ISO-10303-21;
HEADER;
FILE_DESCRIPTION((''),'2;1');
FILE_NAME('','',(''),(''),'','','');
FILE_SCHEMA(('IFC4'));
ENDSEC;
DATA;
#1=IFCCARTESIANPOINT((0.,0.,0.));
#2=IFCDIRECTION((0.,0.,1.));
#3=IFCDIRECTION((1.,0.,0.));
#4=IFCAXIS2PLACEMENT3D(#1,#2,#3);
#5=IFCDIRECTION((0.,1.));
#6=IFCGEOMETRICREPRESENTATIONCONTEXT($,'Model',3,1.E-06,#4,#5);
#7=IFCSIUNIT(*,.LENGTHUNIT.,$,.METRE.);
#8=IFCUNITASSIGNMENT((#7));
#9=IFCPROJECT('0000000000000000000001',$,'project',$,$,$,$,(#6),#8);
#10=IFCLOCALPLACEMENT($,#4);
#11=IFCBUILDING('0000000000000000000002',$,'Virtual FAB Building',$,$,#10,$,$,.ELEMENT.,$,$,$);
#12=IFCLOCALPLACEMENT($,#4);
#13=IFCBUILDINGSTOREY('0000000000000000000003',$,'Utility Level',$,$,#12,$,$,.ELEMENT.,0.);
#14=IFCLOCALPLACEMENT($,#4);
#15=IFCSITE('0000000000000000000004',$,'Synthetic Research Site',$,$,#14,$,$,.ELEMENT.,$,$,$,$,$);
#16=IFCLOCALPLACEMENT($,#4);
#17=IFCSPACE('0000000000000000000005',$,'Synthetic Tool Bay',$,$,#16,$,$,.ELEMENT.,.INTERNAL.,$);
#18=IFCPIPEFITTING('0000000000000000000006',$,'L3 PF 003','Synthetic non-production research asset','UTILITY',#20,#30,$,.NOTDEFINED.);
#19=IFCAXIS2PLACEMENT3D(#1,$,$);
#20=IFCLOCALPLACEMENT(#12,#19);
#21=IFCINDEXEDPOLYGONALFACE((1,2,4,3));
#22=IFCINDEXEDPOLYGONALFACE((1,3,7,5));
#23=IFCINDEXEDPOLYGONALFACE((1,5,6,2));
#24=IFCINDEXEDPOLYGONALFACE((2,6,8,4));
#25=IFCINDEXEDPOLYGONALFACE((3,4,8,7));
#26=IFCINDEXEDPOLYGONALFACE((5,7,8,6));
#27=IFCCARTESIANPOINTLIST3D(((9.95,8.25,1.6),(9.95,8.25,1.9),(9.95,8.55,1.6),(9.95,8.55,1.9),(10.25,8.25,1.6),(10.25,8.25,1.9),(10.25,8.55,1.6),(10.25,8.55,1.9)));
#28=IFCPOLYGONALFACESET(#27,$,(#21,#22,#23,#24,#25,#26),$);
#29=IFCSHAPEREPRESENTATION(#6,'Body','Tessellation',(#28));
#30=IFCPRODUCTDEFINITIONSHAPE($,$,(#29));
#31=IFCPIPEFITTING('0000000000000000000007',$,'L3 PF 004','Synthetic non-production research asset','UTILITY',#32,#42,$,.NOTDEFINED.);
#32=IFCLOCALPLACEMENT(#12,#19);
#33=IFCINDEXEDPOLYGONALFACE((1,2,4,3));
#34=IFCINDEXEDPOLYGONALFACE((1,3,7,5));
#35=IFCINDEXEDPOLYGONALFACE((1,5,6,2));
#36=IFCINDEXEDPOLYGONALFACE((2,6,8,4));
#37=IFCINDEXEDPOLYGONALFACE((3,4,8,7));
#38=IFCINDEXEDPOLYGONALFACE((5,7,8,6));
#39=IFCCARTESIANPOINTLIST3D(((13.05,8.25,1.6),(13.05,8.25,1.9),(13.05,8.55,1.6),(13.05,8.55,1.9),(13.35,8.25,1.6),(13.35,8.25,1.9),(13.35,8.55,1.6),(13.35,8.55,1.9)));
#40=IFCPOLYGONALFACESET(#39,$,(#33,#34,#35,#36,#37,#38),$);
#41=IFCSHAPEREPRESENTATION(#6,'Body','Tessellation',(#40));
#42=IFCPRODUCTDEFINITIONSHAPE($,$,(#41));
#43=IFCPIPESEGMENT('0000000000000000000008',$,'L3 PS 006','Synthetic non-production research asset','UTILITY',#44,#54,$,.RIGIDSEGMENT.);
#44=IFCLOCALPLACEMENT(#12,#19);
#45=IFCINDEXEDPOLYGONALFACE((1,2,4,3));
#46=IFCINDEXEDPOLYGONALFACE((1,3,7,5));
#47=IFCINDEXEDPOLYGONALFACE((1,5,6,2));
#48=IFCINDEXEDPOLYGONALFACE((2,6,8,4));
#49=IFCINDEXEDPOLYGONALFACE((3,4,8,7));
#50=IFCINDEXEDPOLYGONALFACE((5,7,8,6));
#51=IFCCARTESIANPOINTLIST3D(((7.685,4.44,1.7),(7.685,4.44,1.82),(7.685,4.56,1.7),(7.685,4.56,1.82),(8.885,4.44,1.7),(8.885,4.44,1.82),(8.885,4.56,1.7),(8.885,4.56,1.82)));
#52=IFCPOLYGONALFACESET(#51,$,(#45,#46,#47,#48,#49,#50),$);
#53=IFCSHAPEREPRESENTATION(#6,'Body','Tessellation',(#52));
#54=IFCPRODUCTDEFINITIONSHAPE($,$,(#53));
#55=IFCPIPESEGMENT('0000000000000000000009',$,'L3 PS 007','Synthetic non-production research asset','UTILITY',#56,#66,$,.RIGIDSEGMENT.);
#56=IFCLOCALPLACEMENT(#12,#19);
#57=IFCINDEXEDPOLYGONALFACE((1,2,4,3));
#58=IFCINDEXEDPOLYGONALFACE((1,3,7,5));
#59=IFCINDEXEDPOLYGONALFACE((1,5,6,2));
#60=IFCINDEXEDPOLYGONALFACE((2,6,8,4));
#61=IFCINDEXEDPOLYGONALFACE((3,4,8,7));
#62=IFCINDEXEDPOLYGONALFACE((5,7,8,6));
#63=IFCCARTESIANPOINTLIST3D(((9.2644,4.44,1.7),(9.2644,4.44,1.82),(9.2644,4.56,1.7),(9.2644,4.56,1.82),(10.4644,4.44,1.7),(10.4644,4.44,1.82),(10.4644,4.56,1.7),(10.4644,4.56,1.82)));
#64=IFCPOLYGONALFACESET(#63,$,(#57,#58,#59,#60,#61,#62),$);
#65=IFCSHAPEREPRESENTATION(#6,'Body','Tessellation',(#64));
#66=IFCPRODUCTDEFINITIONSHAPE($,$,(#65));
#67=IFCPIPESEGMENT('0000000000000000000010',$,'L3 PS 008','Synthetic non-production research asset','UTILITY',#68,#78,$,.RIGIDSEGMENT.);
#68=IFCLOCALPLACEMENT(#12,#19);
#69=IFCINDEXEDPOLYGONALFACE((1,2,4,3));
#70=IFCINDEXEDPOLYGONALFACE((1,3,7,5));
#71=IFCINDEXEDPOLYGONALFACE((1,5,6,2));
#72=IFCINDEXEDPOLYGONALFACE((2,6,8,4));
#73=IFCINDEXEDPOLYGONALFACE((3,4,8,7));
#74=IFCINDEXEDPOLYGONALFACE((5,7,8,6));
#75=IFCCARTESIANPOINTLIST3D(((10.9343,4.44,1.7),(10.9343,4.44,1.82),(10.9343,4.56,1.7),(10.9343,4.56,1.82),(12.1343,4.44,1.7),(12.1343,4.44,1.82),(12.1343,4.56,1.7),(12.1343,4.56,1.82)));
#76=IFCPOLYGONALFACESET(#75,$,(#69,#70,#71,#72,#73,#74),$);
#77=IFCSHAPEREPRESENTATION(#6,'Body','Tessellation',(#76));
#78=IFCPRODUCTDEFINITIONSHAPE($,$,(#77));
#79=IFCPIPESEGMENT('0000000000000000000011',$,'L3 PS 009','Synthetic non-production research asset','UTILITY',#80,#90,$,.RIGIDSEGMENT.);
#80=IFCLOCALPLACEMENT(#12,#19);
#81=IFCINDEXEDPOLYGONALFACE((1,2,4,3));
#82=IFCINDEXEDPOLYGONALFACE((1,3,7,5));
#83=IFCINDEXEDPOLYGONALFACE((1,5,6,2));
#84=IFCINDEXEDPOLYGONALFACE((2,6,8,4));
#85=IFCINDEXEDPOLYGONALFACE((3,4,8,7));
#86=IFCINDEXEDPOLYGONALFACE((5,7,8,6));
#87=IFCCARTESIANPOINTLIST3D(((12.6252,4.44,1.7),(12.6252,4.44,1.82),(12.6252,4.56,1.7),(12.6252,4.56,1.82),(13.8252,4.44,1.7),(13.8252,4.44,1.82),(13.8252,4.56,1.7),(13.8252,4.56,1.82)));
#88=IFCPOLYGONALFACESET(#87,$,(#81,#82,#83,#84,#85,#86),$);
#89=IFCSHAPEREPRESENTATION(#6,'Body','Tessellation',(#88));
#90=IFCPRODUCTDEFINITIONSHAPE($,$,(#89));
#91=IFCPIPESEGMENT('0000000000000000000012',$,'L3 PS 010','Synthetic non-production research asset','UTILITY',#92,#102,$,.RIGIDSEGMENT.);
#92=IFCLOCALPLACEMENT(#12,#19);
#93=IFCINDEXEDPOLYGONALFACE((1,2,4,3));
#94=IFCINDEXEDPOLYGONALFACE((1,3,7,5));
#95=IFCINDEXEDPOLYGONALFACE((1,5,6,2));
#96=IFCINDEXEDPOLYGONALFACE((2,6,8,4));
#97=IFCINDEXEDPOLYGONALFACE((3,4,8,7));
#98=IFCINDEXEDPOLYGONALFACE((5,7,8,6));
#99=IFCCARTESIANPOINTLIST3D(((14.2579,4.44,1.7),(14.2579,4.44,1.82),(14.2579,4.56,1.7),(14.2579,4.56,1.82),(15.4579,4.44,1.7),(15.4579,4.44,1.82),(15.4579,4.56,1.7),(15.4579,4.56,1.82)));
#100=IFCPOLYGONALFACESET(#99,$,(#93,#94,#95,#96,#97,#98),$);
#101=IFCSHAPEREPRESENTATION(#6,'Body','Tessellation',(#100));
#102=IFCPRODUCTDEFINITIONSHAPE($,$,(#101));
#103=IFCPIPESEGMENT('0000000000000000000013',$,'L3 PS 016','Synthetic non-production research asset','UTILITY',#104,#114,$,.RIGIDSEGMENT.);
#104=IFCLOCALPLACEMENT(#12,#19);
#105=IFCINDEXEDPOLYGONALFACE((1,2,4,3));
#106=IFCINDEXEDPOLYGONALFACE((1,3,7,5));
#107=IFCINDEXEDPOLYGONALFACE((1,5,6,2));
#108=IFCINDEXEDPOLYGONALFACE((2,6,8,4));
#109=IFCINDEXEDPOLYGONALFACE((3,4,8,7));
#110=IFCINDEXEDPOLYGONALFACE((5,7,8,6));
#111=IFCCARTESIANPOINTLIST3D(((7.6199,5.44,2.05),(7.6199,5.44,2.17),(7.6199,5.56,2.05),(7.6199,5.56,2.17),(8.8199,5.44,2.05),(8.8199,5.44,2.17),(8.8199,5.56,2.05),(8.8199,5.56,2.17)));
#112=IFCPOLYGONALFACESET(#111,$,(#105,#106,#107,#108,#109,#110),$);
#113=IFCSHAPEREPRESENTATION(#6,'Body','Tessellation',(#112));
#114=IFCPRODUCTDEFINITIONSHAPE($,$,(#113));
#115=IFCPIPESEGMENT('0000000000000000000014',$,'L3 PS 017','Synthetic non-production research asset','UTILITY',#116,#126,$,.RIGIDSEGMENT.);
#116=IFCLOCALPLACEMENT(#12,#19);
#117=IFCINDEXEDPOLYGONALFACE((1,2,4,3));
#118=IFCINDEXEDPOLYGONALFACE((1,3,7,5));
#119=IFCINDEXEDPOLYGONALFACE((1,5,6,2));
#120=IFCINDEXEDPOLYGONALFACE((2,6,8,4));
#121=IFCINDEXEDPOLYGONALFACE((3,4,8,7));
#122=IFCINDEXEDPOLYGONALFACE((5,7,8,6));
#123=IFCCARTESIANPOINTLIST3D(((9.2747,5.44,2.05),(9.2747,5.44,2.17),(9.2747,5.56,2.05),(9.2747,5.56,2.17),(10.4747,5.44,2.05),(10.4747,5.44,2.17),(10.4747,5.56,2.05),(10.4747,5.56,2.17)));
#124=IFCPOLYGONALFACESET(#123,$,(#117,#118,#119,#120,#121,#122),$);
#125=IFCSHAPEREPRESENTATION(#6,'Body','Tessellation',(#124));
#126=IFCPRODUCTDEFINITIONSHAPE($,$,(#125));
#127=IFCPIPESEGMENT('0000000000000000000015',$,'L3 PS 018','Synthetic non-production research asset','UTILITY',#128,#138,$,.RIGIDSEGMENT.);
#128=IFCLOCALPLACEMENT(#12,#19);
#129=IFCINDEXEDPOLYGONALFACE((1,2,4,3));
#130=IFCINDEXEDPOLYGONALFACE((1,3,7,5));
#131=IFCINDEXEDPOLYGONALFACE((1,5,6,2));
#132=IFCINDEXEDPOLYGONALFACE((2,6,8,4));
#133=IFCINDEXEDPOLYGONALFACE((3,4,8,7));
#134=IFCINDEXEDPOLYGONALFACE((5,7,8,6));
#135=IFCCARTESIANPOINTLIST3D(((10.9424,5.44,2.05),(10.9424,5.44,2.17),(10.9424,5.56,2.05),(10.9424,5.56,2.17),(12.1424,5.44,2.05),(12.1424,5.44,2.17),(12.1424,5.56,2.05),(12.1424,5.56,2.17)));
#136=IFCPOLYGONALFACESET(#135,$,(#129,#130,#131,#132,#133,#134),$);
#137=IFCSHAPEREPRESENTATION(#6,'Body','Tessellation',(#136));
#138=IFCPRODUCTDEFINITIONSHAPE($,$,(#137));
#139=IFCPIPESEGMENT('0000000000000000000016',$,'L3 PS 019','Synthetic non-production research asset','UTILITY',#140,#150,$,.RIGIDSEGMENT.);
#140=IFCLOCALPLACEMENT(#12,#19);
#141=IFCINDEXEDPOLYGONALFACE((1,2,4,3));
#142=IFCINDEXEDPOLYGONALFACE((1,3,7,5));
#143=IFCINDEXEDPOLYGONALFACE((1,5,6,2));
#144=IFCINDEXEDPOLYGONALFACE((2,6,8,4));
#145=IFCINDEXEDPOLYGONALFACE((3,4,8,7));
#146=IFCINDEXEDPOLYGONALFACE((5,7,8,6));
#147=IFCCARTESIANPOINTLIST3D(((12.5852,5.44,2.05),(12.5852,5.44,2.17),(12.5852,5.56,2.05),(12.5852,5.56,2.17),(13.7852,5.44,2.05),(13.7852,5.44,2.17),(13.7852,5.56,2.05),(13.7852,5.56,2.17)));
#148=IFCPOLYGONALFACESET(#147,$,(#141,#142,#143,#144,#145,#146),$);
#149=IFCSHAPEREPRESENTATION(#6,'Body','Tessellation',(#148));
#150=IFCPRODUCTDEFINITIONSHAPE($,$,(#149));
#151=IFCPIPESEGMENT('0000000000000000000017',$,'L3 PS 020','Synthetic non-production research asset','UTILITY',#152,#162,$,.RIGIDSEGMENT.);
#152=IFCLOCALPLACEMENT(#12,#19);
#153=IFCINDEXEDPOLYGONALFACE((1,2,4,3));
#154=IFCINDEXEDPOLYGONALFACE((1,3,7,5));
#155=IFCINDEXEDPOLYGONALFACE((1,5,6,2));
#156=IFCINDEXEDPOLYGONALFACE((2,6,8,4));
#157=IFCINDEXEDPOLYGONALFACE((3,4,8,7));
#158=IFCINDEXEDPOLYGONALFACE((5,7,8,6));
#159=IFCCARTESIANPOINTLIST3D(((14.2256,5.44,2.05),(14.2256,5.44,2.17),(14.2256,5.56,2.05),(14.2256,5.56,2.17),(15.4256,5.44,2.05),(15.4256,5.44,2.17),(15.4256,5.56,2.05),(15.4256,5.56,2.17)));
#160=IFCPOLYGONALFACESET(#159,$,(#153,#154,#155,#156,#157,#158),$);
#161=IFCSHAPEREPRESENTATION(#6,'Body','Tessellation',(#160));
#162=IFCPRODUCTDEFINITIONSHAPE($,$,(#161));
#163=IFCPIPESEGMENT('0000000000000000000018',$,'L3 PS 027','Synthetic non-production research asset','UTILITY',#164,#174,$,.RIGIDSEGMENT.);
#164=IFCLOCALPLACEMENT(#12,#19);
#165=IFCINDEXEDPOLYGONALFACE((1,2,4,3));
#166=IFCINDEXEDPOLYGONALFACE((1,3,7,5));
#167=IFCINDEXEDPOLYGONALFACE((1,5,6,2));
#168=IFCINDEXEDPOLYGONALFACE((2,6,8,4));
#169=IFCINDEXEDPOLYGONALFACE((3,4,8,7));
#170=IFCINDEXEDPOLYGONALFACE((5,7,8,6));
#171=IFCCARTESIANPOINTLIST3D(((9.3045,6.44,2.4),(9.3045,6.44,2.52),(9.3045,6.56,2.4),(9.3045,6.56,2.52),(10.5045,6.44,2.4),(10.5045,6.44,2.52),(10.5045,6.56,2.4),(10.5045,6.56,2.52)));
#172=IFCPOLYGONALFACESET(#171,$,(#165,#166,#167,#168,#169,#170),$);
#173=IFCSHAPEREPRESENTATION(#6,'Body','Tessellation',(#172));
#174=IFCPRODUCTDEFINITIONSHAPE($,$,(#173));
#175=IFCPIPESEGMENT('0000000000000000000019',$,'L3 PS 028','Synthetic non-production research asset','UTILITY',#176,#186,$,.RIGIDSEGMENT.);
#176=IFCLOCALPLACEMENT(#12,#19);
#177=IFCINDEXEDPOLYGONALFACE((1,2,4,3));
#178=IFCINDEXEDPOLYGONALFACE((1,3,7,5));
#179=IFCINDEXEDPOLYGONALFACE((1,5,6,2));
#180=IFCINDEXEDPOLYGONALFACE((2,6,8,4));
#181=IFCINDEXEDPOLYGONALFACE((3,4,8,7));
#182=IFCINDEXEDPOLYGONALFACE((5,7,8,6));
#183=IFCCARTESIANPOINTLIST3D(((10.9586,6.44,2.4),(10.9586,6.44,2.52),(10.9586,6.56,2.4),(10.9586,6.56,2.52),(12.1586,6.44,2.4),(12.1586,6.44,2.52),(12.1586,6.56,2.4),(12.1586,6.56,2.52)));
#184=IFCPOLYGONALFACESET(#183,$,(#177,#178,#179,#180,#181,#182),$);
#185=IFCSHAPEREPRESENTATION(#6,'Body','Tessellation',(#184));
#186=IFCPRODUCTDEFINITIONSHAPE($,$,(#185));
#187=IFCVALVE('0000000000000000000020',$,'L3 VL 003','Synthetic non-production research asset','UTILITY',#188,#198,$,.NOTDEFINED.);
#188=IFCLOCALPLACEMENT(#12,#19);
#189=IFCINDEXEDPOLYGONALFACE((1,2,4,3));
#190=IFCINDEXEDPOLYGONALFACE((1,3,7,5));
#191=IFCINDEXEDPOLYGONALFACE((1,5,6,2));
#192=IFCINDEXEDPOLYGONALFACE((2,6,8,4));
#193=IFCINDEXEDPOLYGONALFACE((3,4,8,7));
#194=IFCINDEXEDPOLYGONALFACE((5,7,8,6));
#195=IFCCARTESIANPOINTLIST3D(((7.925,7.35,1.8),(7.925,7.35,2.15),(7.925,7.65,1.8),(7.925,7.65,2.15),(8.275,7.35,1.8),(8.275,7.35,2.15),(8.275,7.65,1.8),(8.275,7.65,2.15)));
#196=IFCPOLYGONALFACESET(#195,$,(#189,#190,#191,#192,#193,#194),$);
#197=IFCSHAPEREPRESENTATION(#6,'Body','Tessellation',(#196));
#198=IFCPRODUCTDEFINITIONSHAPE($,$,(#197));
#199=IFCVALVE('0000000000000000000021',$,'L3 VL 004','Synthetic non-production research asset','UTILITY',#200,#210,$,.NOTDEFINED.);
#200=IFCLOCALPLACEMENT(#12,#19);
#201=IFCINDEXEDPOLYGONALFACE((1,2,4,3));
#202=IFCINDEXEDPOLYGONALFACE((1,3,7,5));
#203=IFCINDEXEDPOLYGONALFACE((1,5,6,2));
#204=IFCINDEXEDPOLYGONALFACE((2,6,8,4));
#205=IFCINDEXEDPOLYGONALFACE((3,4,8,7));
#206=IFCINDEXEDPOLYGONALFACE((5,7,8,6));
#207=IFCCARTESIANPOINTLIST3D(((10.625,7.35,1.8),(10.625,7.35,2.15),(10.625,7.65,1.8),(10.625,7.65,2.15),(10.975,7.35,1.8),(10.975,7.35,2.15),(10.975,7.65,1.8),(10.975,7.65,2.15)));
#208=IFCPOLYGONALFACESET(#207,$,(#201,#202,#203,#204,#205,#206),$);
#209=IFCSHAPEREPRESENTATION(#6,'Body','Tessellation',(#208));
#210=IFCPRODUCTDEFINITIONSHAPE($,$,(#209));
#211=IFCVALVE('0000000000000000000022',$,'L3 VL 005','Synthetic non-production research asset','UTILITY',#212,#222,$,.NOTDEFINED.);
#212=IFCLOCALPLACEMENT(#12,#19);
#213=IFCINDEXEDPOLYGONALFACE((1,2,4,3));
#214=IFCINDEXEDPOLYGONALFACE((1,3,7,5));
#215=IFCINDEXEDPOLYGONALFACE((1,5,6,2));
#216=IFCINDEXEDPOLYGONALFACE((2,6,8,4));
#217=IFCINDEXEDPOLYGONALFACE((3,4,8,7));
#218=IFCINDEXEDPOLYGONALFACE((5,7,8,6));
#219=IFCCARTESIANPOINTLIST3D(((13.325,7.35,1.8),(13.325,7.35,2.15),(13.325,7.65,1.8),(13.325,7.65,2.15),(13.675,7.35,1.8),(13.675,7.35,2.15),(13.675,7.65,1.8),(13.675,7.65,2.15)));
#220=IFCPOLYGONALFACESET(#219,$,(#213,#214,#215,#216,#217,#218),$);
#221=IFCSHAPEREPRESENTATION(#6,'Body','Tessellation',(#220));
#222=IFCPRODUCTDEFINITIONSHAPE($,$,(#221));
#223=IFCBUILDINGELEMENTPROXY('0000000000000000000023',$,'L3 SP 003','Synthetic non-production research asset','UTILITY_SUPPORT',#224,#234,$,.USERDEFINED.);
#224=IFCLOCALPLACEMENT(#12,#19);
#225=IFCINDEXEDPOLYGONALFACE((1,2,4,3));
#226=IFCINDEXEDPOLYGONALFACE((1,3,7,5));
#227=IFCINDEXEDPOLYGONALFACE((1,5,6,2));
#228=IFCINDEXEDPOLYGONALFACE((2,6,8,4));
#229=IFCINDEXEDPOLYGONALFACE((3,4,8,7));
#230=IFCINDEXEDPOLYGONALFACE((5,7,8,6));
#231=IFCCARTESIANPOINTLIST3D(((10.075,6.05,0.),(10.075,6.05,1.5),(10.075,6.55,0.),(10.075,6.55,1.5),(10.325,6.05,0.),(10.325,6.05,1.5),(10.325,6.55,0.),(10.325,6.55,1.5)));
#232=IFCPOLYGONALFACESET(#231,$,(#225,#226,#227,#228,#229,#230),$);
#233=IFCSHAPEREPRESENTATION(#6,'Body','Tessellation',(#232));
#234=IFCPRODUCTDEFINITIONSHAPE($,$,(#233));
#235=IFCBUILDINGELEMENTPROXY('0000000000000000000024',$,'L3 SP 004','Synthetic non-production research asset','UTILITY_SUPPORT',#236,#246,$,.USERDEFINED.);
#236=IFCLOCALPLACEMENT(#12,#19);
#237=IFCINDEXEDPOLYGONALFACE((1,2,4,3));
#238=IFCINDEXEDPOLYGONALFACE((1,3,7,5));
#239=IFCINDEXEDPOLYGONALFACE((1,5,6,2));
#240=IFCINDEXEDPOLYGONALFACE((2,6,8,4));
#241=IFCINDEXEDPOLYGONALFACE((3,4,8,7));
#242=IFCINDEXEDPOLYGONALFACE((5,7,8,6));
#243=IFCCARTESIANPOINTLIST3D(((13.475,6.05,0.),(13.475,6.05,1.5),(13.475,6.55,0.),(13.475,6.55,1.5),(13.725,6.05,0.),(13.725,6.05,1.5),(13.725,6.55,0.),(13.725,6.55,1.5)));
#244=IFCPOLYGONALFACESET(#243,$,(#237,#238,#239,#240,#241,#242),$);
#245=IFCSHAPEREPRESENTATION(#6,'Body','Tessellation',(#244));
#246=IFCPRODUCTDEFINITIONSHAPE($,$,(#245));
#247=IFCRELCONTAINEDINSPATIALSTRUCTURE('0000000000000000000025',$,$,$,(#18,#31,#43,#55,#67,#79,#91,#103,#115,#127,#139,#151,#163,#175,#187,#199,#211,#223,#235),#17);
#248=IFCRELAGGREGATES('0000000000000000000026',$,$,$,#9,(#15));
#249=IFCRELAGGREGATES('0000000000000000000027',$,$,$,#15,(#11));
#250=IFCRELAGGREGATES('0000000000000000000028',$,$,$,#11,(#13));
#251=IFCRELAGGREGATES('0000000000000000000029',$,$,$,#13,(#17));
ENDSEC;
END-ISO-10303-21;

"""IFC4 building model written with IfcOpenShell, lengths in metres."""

from ifc_helpers import new_model, si_unit, direction, frame, origin_with_axes, origin_2d_with_axis, place, context, project, spatial, rectangle, extrude, element, save


model = new_model("IFC4")

# Units and contexts
model_context = context("Model", 3, precision=1e-06, world=origin_with_axes(), true_north=direction((0.0, 1.0)))
ifc_project = project(units=[si_unit("LENGTHUNIT", "METRE")], contexts=[model_context])

# Site, building, storey, space
site_placement = place(None, origin_with_axes())
site = spatial("IfcSite", under=ifc_project, at=site_placement, Name="Synthetic Research Site", CompositionType="ELEMENT")
building_placement = place(None, origin_with_axes())
building = spatial("IfcBuilding", under=site, at=building_placement, Name="Virtual FAB Building", CompositionType="ELEMENT")
storey_placement = place(None, origin_with_axes())
storey = spatial("IfcBuildingStorey", under=building, at=storey_placement, Name="Utility Level", CompositionType="ELEMENT", Elevation=0.0)
space_placement = place(None, origin_with_axes())
space = spatial("IfcSpace", under=storey, at=space_placement, Name="Synthetic Tool Bay", CompositionType="ELEMENT", PredefinedType="INTERNAL")

# Pipe fittings
for number, where, z_axis, x_axis, name in (
    (1, (10.1, 8.4, 1.6), (0.0, 0.0, 1.0), (1.0, 0.0, 0.0), "L3 PF 003"),
    (2, (13.2, 8.4, 1.6), (0.0, 0.0, 1.0), (1.0, 0.0, 0.0), "L3 PF 004"),
):
    element("IfcPipeFitting", number, at=place(None, frame(where, z_axis=z_axis, x_axis=x_axis)), inside=space, Name=name, Description="Synthetic non-production research asset", ObjectType="UTILITY", PredefinedType="NOTDEFINED", context=model_context, shape_type="SweptSolid", body=[
        extrude(rectangle(XDim=0.3, YDim=0.3, at=origin_2d_with_axis()), origin_with_axes(), (0.0, 0.0, 1.0), 0.3),
    ])

# Pipe segments
for number, where, z_axis, x_axis, name in (
    (3, (8.285, 4.5, 1.7), (0.0, 0.0, 1.0), (1.0, 0.0, 0.0), "L3 PS 006"),
    (4, (9.8644, 4.5, 1.7), (0.0, 0.0, 1.0), (1.0, 0.0, 0.0), "L3 PS 007"),
    (5, (11.5343, 4.5, 1.7), (0.0, 0.0, 1.0), (1.0, 0.0, 0.0), "L3 PS 008"),
    (6, (13.2252, 4.5, 1.7), (0.0, 0.0, 1.0), (1.0, 0.0, 0.0), "L3 PS 009"),
    (7, (14.8579, 4.5, 1.7), (0.0, 0.0, 1.0), (1.0, 0.0, 0.0), "L3 PS 010"),
    (8, (8.2199, 5.5, 2.05), (0.0, 0.0, 1.0), (1.0, 0.0, 0.0), "L3 PS 016"),
    (9, (9.8747, 5.5, 2.05), (0.0, 0.0, 1.0), (1.0, 0.0, 0.0), "L3 PS 017"),
    (10, (11.5424, 5.5, 2.05), (0.0, 0.0, 1.0), (1.0, 0.0, 0.0), "L3 PS 018"),
    (11, (13.1852, 5.5, 2.05), (0.0, 0.0, 1.0), (1.0, 0.0, 0.0), "L3 PS 019"),
    (12, (14.8256, 5.5, 2.05), (0.0, 0.0, 1.0), (1.0, 0.0, 0.0), "L3 PS 020"),
    (13, (9.9045, 6.5, 2.4), (0.0, 0.0, 1.0), (1.0, 0.0, 0.0), "L3 PS 027"),
    (14, (11.5586, 6.5, 2.4), (0.0, 0.0, 1.0), (1.0, 0.0, 0.0), "L3 PS 028"),
):
    element("IfcPipeSegment", number, at=place(None, frame(where, z_axis=z_axis, x_axis=x_axis)), inside=space, Name=name, Description="Synthetic non-production research asset", ObjectType="UTILITY", PredefinedType="RIGIDSEGMENT", context=model_context, shape_type="SweptSolid", body=[
        extrude(rectangle(XDim=1.2, YDim=0.12, at=origin_2d_with_axis()), origin_with_axes(), (0.0, 0.0, 1.0), 0.12),
    ])

# Valves
for number, where, z_axis, x_axis, name in (
    (15, (8.1, 7.5, 1.8), (0.0, 0.0, 1.0), (1.0, 0.0, 0.0), "L3 VL 003"),
    (16, (10.8, 7.5, 1.8), (0.0, 0.0, 1.0), (1.0, 0.0, 0.0), "L3 VL 004"),
    (17, (13.5, 7.5, 1.8), (0.0, 0.0, 1.0), (1.0, 0.0, 0.0), "L3 VL 005"),
):
    element("IfcValve", number, at=place(None, frame(where, z_axis=z_axis, x_axis=x_axis)), inside=space, Name=name, Description="Synthetic non-production research asset", ObjectType="UTILITY", PredefinedType="NOTDEFINED", context=model_context, shape_type="SweptSolid", body=[
        extrude(rectangle(XDim=0.35, YDim=0.3, at=origin_2d_with_axis()), origin_with_axes(), (0.0, 0.0, 1.0), 0.35),
    ])

# Building element proxies
for number, where, z_axis, x_axis, name in (
    (18, (10.2, 6.3, 0.0), (0.0, 0.0, 1.0), (1.0, 0.0, 0.0), "L3 SP 003"),
    (19, (13.6, 6.3, 0.0), (0.0, 0.0, 1.0), (1.0, 0.0, 0.0), "L3 SP 004"),
):
    element("IfcBuildingElementProxy", number, at=place(None, frame(where, z_axis=z_axis, x_axis=x_axis)), inside=space, Name=name, Description="Synthetic non-production research asset", ObjectType="UTILITY_SUPPORT", PredefinedType="USERDEFINED", context=model_context, shape_type="SweptSolid", body=[
        extrude(rectangle(XDim=0.25, YDim=0.5, at=origin_2d_with_axis()), origin_with_axes(), (0.0, 0.0, 1.0), 1.5),
    ])

save(model, "model.ifc")
